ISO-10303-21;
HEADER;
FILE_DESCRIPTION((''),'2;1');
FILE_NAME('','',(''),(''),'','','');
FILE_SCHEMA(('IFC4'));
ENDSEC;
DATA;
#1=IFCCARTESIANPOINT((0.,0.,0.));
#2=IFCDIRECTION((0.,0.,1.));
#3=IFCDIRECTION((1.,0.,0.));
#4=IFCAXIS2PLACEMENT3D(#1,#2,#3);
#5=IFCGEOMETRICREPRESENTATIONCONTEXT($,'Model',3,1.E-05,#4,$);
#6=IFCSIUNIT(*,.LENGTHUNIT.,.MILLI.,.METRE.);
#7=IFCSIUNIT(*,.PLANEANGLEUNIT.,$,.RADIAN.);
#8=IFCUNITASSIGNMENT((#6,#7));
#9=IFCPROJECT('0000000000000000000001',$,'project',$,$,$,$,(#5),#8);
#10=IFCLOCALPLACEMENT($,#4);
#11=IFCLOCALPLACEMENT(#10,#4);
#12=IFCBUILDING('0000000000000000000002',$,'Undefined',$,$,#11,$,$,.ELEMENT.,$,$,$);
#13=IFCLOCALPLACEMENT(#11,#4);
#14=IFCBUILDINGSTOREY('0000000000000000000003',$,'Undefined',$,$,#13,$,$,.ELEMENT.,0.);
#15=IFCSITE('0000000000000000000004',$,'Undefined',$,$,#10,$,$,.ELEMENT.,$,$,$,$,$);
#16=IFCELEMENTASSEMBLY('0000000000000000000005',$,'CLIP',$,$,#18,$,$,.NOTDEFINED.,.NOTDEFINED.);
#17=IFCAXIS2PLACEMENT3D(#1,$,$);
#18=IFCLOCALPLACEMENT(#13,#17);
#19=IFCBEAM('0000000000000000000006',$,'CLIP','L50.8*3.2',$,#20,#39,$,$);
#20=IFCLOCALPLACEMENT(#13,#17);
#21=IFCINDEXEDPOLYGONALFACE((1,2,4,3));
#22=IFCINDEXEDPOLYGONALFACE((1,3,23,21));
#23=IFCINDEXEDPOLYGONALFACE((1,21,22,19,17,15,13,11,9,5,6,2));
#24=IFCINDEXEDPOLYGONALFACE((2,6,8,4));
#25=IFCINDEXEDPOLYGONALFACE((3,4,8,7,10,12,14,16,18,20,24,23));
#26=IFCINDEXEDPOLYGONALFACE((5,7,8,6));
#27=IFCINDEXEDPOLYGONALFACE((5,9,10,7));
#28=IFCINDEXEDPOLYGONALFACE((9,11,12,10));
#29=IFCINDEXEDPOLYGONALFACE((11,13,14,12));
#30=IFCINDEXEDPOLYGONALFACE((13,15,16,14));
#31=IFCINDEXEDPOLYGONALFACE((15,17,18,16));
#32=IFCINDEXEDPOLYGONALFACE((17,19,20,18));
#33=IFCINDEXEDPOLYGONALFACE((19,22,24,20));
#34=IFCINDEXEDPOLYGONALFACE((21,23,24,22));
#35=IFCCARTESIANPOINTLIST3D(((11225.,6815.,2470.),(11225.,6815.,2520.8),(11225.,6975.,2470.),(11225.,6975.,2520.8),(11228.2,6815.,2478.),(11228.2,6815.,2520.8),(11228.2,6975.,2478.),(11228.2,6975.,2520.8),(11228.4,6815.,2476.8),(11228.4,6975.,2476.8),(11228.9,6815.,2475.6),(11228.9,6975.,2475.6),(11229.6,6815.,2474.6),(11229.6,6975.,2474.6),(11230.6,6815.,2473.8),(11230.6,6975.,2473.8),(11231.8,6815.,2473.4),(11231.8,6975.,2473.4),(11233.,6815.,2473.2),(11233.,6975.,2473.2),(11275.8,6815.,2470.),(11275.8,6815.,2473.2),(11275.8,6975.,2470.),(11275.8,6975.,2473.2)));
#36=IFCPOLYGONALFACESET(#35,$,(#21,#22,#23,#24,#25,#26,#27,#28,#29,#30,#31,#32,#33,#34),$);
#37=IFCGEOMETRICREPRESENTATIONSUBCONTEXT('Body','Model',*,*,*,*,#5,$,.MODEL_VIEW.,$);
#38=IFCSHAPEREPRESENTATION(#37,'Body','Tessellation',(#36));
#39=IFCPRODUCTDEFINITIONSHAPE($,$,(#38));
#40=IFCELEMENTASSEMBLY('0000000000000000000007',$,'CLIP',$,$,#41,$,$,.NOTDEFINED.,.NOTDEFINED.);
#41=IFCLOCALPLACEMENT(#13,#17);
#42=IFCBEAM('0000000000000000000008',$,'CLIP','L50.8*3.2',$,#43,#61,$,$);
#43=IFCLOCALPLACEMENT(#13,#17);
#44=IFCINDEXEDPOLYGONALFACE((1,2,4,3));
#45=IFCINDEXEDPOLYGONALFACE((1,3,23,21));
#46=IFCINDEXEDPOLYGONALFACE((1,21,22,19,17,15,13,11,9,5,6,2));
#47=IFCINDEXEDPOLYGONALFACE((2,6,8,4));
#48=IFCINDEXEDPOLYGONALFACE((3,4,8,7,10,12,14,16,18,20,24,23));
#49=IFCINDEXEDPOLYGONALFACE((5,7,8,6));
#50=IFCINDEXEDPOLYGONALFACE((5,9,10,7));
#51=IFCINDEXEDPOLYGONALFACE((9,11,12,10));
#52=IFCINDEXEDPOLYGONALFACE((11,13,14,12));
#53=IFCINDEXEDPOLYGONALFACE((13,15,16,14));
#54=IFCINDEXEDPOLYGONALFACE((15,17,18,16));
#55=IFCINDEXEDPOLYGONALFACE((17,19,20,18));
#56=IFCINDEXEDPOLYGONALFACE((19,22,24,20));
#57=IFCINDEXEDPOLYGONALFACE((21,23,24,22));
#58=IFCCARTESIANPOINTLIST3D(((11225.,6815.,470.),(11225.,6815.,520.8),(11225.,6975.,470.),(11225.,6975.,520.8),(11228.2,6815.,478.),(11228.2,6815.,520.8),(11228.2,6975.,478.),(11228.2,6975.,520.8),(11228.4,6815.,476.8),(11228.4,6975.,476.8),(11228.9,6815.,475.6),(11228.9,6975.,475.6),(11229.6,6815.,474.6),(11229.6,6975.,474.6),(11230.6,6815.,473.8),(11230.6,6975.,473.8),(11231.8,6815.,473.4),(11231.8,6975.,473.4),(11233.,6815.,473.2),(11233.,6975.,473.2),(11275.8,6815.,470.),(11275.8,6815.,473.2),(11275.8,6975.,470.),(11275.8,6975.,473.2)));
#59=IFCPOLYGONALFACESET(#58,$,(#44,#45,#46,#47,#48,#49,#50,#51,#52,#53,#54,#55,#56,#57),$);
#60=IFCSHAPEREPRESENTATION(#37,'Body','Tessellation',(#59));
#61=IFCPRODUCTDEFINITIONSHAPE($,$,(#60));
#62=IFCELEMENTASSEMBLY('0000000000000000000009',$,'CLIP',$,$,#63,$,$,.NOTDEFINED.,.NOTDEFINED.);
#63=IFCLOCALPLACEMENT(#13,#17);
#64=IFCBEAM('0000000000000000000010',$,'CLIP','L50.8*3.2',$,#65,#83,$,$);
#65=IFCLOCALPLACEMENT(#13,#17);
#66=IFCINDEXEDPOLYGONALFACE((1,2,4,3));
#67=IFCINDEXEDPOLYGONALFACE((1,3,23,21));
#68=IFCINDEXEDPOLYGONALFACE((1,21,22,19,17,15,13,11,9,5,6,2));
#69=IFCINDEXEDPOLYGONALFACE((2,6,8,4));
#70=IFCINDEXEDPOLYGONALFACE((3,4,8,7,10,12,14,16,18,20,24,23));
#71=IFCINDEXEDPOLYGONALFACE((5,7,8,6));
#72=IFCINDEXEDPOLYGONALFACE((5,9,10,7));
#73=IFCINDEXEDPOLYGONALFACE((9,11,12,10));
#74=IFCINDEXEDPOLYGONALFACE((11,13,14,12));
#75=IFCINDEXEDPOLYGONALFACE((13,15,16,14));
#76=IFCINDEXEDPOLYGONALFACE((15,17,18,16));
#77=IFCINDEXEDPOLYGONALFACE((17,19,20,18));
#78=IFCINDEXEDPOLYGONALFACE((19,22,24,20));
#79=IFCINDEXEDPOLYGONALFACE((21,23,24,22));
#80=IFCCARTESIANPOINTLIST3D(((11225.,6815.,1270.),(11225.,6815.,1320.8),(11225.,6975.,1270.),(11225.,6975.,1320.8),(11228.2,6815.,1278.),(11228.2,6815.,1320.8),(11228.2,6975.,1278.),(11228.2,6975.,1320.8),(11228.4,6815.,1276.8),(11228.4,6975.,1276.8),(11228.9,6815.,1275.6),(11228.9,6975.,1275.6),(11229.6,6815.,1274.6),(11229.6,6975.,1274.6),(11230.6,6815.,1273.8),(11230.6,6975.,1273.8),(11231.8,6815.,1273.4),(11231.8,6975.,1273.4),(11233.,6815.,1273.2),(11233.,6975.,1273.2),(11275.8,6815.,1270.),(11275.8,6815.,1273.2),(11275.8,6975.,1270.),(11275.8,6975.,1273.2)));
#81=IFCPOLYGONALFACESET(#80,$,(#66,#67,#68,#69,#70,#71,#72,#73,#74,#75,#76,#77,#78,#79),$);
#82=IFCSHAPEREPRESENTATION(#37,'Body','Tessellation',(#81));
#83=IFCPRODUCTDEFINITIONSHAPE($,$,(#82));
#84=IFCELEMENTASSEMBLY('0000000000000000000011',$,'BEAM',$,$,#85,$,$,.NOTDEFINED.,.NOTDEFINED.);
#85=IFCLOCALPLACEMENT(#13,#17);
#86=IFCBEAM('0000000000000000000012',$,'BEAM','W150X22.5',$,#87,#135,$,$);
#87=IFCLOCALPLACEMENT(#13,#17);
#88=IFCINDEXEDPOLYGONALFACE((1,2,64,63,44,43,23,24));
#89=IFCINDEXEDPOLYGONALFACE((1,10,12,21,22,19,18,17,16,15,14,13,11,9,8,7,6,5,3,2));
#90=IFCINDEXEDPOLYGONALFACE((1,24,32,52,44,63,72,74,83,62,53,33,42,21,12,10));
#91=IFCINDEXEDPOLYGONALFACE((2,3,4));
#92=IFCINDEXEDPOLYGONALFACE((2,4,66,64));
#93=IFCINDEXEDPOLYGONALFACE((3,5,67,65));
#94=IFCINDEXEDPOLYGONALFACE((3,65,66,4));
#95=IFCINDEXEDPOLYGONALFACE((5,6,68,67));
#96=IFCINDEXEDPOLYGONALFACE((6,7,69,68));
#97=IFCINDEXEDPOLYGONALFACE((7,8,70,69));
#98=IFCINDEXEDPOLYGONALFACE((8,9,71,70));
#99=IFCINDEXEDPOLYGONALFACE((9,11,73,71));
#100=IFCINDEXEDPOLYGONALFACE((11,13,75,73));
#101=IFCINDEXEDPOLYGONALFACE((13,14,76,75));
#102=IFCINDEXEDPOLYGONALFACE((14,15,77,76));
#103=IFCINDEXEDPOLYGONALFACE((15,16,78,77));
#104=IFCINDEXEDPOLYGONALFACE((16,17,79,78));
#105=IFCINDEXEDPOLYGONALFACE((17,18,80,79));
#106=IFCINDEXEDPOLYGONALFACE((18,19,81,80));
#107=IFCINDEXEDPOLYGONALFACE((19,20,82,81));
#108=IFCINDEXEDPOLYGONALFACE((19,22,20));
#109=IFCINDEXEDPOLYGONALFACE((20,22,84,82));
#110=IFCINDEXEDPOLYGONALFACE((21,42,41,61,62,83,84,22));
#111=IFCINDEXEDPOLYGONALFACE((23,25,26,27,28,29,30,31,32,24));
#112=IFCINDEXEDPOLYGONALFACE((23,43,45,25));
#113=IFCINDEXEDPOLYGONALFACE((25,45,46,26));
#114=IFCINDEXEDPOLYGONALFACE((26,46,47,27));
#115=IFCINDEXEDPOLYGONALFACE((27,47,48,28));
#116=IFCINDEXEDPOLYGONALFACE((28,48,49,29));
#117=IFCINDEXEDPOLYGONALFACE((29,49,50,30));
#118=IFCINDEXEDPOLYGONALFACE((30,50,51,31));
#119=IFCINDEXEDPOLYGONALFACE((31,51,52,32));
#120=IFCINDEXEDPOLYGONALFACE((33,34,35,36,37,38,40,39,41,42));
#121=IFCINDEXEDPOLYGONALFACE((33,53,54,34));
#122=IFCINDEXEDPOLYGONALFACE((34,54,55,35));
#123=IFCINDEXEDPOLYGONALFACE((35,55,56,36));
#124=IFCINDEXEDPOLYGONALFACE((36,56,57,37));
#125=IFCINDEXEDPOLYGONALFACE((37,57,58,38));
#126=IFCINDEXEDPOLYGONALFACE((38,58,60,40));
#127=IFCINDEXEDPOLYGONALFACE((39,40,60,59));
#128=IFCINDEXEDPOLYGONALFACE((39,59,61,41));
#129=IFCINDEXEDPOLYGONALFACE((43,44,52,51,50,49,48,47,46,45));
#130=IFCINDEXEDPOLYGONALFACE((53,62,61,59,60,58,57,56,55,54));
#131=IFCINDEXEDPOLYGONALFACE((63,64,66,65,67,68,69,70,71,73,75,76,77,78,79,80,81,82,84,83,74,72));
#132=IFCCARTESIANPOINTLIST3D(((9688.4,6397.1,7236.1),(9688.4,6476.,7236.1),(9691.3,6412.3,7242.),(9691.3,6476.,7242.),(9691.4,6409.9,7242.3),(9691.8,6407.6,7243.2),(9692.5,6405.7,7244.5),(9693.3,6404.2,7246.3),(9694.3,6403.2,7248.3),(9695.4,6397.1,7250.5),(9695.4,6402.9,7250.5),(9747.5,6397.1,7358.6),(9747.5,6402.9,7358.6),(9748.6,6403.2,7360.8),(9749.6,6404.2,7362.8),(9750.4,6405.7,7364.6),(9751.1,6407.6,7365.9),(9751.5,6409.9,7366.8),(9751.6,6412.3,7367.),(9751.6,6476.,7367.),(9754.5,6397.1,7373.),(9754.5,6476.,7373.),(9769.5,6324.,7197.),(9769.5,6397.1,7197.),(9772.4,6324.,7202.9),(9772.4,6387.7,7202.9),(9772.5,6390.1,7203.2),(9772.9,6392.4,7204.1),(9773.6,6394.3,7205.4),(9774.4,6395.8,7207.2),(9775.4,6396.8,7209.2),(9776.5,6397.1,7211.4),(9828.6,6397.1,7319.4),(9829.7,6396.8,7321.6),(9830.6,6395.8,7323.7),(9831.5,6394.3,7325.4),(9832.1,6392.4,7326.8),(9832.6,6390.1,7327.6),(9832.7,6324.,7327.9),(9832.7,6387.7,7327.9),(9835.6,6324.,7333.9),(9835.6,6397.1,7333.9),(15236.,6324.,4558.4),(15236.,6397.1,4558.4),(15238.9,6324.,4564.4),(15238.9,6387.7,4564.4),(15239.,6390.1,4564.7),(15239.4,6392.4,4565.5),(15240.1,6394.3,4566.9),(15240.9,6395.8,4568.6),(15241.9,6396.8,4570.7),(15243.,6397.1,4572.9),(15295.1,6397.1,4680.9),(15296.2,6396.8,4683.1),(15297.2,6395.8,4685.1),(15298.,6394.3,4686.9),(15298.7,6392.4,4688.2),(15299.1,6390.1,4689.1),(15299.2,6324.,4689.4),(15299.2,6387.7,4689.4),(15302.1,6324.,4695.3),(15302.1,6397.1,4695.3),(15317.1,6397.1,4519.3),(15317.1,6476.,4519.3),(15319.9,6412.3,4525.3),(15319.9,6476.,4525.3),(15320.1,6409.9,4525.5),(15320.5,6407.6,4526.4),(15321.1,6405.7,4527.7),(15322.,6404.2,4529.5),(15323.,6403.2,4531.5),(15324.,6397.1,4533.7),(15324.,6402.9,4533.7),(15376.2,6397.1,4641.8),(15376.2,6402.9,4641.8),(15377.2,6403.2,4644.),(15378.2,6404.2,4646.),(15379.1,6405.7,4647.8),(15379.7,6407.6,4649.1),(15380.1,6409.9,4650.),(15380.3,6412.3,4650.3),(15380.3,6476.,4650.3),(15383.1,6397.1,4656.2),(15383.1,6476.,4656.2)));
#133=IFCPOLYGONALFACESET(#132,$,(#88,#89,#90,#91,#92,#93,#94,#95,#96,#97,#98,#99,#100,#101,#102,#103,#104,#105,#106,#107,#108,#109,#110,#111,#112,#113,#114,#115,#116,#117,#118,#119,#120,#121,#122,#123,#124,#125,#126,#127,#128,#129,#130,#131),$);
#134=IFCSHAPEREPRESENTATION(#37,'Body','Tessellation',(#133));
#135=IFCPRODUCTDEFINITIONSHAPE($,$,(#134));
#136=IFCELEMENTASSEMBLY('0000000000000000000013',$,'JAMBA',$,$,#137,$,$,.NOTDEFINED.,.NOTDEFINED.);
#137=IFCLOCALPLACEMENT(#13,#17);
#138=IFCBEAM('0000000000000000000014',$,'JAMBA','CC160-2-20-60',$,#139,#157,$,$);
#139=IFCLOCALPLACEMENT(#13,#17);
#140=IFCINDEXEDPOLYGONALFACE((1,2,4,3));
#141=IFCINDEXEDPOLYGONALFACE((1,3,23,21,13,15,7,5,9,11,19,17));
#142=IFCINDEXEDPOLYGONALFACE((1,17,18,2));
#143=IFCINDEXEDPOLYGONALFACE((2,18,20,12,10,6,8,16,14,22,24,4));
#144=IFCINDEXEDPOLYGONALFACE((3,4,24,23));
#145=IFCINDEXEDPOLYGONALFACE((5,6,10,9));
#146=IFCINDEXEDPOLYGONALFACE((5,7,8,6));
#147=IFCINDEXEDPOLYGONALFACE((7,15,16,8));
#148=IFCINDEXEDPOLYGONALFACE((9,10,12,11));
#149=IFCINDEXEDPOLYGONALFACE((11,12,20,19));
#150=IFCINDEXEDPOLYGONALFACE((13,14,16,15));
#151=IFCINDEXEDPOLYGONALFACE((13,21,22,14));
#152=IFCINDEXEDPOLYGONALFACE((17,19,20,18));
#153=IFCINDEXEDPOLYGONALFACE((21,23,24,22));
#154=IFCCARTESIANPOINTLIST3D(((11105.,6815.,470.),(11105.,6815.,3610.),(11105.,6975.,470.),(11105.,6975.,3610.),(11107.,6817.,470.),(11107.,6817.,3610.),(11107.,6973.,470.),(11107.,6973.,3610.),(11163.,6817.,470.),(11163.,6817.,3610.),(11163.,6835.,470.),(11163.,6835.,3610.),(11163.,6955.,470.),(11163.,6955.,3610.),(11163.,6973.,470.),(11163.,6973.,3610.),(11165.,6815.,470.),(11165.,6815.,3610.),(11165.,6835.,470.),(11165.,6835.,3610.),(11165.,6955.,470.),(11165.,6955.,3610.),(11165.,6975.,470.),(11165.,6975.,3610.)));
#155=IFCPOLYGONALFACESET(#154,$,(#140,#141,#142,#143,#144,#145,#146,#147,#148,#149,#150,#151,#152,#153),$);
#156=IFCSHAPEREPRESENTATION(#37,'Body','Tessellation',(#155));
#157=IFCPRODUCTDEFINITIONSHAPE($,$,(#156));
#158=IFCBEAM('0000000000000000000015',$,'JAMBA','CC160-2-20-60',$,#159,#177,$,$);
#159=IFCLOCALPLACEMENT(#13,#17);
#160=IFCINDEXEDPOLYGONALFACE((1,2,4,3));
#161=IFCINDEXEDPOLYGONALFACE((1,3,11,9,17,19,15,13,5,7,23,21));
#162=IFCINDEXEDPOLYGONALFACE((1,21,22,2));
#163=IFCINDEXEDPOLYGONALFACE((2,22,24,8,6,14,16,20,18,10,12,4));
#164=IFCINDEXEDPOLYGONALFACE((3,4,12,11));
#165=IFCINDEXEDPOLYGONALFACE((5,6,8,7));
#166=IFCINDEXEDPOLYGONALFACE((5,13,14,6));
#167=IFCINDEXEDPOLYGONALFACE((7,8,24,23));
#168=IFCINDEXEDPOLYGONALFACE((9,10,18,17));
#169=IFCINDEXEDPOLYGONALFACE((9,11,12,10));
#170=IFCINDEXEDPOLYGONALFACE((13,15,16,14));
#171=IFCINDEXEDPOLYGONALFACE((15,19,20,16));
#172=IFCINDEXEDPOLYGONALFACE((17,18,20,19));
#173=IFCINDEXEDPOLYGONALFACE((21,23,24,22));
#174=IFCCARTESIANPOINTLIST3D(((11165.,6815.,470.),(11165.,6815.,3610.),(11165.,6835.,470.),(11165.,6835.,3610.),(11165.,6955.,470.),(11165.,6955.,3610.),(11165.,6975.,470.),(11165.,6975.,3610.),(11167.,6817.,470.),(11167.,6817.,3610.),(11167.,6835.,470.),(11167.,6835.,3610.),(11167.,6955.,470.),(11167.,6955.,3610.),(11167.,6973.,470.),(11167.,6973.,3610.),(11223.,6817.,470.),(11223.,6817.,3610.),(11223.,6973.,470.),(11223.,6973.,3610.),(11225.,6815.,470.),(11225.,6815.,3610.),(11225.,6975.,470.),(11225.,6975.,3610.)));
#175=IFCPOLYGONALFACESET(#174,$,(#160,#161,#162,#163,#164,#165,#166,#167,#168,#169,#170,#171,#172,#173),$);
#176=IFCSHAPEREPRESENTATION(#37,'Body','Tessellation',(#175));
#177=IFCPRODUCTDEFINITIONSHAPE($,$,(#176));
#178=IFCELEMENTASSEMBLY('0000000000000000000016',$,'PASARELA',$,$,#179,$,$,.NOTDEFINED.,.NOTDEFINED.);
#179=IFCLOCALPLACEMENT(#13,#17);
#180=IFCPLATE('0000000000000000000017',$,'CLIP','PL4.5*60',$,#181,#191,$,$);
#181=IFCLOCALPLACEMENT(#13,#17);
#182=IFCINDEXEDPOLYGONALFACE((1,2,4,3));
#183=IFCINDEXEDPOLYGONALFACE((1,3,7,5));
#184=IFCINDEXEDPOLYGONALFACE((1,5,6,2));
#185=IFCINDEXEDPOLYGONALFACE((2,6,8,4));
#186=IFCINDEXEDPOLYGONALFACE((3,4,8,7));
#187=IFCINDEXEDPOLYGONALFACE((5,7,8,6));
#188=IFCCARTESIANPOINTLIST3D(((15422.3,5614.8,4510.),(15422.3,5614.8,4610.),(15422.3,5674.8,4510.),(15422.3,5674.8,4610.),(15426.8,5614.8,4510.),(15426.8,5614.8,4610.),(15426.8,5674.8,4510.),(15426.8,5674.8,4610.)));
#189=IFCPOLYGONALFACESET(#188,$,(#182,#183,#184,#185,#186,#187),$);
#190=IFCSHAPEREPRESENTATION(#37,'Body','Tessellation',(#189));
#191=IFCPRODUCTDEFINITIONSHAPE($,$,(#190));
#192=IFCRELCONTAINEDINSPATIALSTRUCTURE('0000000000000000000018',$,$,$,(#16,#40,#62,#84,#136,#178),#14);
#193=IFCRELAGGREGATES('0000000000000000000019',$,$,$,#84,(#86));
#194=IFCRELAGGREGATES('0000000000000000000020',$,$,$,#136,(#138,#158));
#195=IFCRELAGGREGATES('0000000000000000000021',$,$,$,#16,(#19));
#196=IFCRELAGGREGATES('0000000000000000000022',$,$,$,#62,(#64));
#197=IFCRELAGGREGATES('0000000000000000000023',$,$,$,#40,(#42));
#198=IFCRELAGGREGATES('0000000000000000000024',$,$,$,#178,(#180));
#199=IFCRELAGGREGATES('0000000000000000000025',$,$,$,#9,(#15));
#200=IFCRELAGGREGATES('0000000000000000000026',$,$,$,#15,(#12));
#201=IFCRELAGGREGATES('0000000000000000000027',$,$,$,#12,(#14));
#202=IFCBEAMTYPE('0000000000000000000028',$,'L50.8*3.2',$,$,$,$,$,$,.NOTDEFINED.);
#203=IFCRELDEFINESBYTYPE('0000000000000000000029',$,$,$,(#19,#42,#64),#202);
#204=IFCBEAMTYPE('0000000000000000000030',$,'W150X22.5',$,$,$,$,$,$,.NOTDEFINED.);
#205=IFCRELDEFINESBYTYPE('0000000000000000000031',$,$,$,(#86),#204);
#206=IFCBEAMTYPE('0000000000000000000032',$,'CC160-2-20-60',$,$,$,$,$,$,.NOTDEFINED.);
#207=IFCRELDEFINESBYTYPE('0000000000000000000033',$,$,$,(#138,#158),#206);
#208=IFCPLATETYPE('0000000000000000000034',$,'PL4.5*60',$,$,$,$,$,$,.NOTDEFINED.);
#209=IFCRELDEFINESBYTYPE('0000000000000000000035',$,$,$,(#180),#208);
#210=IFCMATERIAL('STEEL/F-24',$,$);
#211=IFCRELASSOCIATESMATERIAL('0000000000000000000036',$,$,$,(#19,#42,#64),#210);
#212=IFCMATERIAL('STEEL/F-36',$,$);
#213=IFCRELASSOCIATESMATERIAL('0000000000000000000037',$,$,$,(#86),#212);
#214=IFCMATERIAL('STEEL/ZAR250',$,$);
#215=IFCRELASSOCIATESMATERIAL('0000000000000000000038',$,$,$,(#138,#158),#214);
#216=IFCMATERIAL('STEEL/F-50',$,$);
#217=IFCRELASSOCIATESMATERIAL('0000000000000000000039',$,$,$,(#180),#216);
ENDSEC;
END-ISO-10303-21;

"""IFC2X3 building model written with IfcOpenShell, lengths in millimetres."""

from ifc_helpers import new_model, si_unit, frame, origin_with_axes, origin_2d_with_axis, place, context, subcontext, project, spatial, polyline, i_section, l_section, c_section, outline, extrude, boolean, material, type_object, element, aggregate, save


model = new_model("IFC2X3")

# Units and contexts
model_context = context("Model", 3, precision=1e-05, world=origin_with_axes())
body_context = subcontext(model_context, "Body", "Model", "MODEL_VIEW")
ifc_project = project(units=[si_unit("LENGTHUNIT", "METRE", prefix="MILLI"), si_unit("PLANEANGLEUNIT", "RADIAN")], contexts=[model_context])

# Site, building, storey
site_placement = place(None, origin_with_axes())
site = spatial("IfcSite", under=ifc_project, at=site_placement, Name="Undefined", CompositionType="ELEMENT")
building_placement = place(site_placement, origin_with_axes())
building = spatial("IfcBuilding", under=site, at=building_placement, Name="Undefined", CompositionType="ELEMENT")
storey_placement = place(building_placement, origin_with_axes())
storey = spatial("IfcBuildingStorey", under=building, at=storey_placement, Name="Undefined", CompositionType="ELEMENT", Elevation=0.0)

# Shared definitions
ifc_material_1 = material(Name="STEEL/F-24")

# Element assemblies, beams
beam_type_1 = type_object("IfcBeamType", Name="L50.8*3.2", PredefinedType="NOTDEFINED")
assembly_1_placement = place(storey_placement, origin_with_axes())
assembly_1 = element("IfcElementAssembly", 1, at=assembly_1_placement, inside=storey, Name="CLIP", AssemblyPlace="NOTDEFINED", PredefinedType="NOTDEFINED")
beam_1_placement = place(assembly_1_placement, frame((11250.4, 6975.0, 2495.4), z_axis=(1.0, 0.0, 0.0), x_axis=(0.0, -1.0, 0.0)))
beam_1 = element("IfcBeam", 2, at=beam_1_placement, type_object=beam_type_1, material=ifc_material_1, Name="CLIP", Description="L50.8*3.2", context=body_context, shape_type="SweptSolid", body=[
    extrude(l_section(Depth=50.8, Width=50.8, Thickness=3.2, FilletRadius=4.8, at=origin_2d_with_axis()), frame((160.0, 0.0, 0.0), z_axis=(-1.0, 0.0, 0.0), x_axis=(0.0, -1.0, 0.0)), (0.0, 0.0, 1.0), 160.0),
])
assembly_2_placement = place(storey_placement, origin_with_axes())
assembly_2 = element("IfcElementAssembly", 3, at=assembly_2_placement, inside=storey, Name="CLIP", AssemblyPlace="NOTDEFINED", PredefinedType="NOTDEFINED")
beam_2_placement = place(assembly_2_placement, frame((11250.4, 6975.0, 495.4), z_axis=(1.0, 0.0, 0.0), x_axis=(0.0, -1.0, 0.0)))
beam_2 = element("IfcBeam", 4, at=beam_2_placement, type_object=beam_type_1, material=ifc_material_1, Name="CLIP", Description="L50.8*3.2", context=body_context, shape_type="SweptSolid", body=[
    extrude(l_section(Depth=50.8, Width=50.8, Thickness=3.2, FilletRadius=4.8, at=origin_2d_with_axis()), frame((160.0, 0.0, 0.0), z_axis=(-1.0, 0.0, 0.0), x_axis=(0.0, -1.0, 0.0)), (0.0, 0.0, 1.0), 160.0),
])
assembly_3_placement = place(storey_placement, origin_with_axes())
assembly_3 = element("IfcElementAssembly", 5, at=assembly_3_placement, inside=storey, Name="CLIP", AssemblyPlace="NOTDEFINED", PredefinedType="NOTDEFINED")
beam_3_placement = place(assembly_3_placement, frame((11250.4, 6975.0, 1295.4), z_axis=(1.0, 0.0, 0.0), x_axis=(0.0, -1.0, 0.0)))
beam_3 = element("IfcBeam", 6, at=beam_3_placement, type_object=beam_type_1, material=ifc_material_1, Name="CLIP", Description="L50.8*3.2", context=body_context, shape_type="SweptSolid", body=[
    extrude(l_section(Depth=50.8, Width=50.8, Thickness=3.2, FilletRadius=4.8, at=origin_2d_with_axis()), frame((160.0, 0.0, 0.0), z_axis=(-1.0, 0.0, 0.0), x_axis=(0.0, -1.0, 0.0)), (0.0, 0.0, 1.0), 160.0),
])
assembly_4_placement = place(storey_placement, origin_with_axes())
assembly_4 = element("IfcElementAssembly", 7, at=assembly_4_placement, inside=storey, Name="BEAM", AssemblyPlace="NOTDEFINED", PredefinedType="NOTDEFINED")
ifc_material_2 = material(Name="STEEL/F-36")
beam_type_2 = type_object("IfcBeamType", Name="W150X22.5", PredefinedType="NOTDEFINED")
beam_4_placement = place(assembly_4_placement, frame((15350.1, 6400.0, 4587.8), z_axis=(0.434685, 0.0, 0.900582), x_axis=(-0.900582, 0.0, 0.434685)))
beam_4 = element("IfcBeam", 8, at=beam_4_placement, type_object=beam_type_2, material=ifc_material_2, Name="BEAM", Description="W150X22.5", context=body_context, shape_type="CSG", body=[
    boolean("DIFFERENCE", boolean("DIFFERENCE", extrude(i_section(OverallWidth=152.0, OverallDepth=152.0, WebThickness=5.8, FlangeThickness=6.6, FilletRadius=9.4, at=origin_2d_with_axis()), frame((6250.0, 0.0, 0.0), z_axis=(-1.0, 0.0, 0.0), x_axis=(0.0, -1.0, 0.0)), (0.0, 0.0, 1.0), 6250.0), extrude(outline(polyline([(0.0, 0.0), (90.0, 0.0), (90.0, 73.1), (0.0, 73.1), (0.0, 0.0)])), frame((6250.0, 2.9, 79.0), z_axis=(0.0, 0.0, -1.0), x_axis=(-1.0, -0.000031, 0.0)), (0.0, 0.0, 1.0), 158.0)), extrude(outline(polyline([(0.0, 0.0), (90.0, 0.0), (90.0, 73.1), (0.0, 73.1), (0.0, 0.0)])), frame((0.0, 2.9, -79.0), z_axis=(0.0, 0.0, 1.0), x_axis=(1.0, -0.000031, 0.0)), (0.0, 0.0, 1.0), 158.0)),
])
aggregate(assembly_4, [beam_4])

# Element assembly, beams
assembly_5_placement = place(storey_placement, origin_with_axes())
assembly_5 = element("IfcElementAssembly", 9, at=assembly_5_placement, inside=storey, Name="JAMBA", AssemblyPlace="NOTDEFINED", PredefinedType="NOTDEFINED")
ifc_material_3 = material(Name="STEEL/ZAR250")
beam_type_3 = type_object("IfcBeamType", Name="CC160-2-20-60", PredefinedType="NOTDEFINED")
beam_5_placement = place(assembly_5_placement, frame((11135.0, 6895.0, 3610.0), z_axis=(0.0, 1.0, 0.0), x_axis=(0.0, 0.0, -1.0)))
beam_5 = element("IfcBeam", 10, at=beam_5_placement, type_object=beam_type_3, material=ifc_material_3, Name="JAMBA", Description="CC160-2-20-60", context=body_context, shape_type="SweptSolid", body=[
    extrude(c_section(Depth=160.0, Width=60.0, WallThickness=2.0, Girth=20.0, at=origin_2d_with_axis()), frame((3140.0, 0.0, 0.0), z_axis=(-1.0, 0.0, 0.0), x_axis=(0.0, -1.0, 0.0)), (0.0, 0.0, 1.0), 3140.0),
])
beam_6_placement = place(assembly_5_placement, frame((11195.0, 6895.0, 470.0), z_axis=(0.0, 1.0, 0.0), x_axis=(0.0, 0.0, 1.0)))
beam_6 = element("IfcBeam", 11, at=beam_6_placement, type_object=beam_type_3, material=ifc_material_3, Name="JAMBA", Description="CC160-2-20-60", context=body_context, shape_type="SweptSolid", body=[
    extrude(c_section(Depth=160.0, Width=60.0, WallThickness=2.0, Girth=20.0, at=origin_2d_with_axis()), frame((3140.0, 0.0, 0.0), z_axis=(-1.0, 0.0, 0.0), x_axis=(0.0, -1.0, 0.0)), (0.0, 0.0, 1.0), 3140.0),
])
aggregate(assembly_5, [beam_5, beam_6])

# Element assembly, plate
assembly_6_placement = place(storey_placement, origin_with_axes())
assembly_6 = element("IfcElementAssembly", 12, at=assembly_6_placement, inside=storey, Name="PASARELA", AssemblyPlace="NOTDEFINED", PredefinedType="NOTDEFINED")
ifc_material_4 = material(Name="STEEL/F-50")
plate_type_1 = type_object("IfcPlateType", Name="PL4.5*60", PredefinedType="NOTDEFINED")
plate_1_placement = place(assembly_6_placement, frame((15424.5, 5674.8, 4510.0), z_axis=(-1.0, 0.0, 0.0), x_axis=(0.000001, -1.0, 0.000014)))
plate_1 = element("IfcPlate", 13, at=plate_1_placement, type_object=plate_type_1, material=ifc_material_4, Name="CLIP", Description="PL4.5*60", context=body_context, shape_type="SweptSolid", body=[
    extrude(outline(polyline([(0.0, 0.0), (60.0, 0.0), (60.0, 100.0), (0.0, 100.0), (0.0, 0.0)])), frame((0.0, 0.0, -2.2), z_axis=(0.0, 0.0, 1.0), x_axis=(1.0, 0.0, 0.0)), (0.0, 0.0, 1.0), 4.5),
])

aggregate(assembly_1, [beam_1])
aggregate(assembly_3, [beam_3])
aggregate(assembly_2, [beam_2])
aggregate(assembly_6, [plate_1])

save(model, "model.ifc")
